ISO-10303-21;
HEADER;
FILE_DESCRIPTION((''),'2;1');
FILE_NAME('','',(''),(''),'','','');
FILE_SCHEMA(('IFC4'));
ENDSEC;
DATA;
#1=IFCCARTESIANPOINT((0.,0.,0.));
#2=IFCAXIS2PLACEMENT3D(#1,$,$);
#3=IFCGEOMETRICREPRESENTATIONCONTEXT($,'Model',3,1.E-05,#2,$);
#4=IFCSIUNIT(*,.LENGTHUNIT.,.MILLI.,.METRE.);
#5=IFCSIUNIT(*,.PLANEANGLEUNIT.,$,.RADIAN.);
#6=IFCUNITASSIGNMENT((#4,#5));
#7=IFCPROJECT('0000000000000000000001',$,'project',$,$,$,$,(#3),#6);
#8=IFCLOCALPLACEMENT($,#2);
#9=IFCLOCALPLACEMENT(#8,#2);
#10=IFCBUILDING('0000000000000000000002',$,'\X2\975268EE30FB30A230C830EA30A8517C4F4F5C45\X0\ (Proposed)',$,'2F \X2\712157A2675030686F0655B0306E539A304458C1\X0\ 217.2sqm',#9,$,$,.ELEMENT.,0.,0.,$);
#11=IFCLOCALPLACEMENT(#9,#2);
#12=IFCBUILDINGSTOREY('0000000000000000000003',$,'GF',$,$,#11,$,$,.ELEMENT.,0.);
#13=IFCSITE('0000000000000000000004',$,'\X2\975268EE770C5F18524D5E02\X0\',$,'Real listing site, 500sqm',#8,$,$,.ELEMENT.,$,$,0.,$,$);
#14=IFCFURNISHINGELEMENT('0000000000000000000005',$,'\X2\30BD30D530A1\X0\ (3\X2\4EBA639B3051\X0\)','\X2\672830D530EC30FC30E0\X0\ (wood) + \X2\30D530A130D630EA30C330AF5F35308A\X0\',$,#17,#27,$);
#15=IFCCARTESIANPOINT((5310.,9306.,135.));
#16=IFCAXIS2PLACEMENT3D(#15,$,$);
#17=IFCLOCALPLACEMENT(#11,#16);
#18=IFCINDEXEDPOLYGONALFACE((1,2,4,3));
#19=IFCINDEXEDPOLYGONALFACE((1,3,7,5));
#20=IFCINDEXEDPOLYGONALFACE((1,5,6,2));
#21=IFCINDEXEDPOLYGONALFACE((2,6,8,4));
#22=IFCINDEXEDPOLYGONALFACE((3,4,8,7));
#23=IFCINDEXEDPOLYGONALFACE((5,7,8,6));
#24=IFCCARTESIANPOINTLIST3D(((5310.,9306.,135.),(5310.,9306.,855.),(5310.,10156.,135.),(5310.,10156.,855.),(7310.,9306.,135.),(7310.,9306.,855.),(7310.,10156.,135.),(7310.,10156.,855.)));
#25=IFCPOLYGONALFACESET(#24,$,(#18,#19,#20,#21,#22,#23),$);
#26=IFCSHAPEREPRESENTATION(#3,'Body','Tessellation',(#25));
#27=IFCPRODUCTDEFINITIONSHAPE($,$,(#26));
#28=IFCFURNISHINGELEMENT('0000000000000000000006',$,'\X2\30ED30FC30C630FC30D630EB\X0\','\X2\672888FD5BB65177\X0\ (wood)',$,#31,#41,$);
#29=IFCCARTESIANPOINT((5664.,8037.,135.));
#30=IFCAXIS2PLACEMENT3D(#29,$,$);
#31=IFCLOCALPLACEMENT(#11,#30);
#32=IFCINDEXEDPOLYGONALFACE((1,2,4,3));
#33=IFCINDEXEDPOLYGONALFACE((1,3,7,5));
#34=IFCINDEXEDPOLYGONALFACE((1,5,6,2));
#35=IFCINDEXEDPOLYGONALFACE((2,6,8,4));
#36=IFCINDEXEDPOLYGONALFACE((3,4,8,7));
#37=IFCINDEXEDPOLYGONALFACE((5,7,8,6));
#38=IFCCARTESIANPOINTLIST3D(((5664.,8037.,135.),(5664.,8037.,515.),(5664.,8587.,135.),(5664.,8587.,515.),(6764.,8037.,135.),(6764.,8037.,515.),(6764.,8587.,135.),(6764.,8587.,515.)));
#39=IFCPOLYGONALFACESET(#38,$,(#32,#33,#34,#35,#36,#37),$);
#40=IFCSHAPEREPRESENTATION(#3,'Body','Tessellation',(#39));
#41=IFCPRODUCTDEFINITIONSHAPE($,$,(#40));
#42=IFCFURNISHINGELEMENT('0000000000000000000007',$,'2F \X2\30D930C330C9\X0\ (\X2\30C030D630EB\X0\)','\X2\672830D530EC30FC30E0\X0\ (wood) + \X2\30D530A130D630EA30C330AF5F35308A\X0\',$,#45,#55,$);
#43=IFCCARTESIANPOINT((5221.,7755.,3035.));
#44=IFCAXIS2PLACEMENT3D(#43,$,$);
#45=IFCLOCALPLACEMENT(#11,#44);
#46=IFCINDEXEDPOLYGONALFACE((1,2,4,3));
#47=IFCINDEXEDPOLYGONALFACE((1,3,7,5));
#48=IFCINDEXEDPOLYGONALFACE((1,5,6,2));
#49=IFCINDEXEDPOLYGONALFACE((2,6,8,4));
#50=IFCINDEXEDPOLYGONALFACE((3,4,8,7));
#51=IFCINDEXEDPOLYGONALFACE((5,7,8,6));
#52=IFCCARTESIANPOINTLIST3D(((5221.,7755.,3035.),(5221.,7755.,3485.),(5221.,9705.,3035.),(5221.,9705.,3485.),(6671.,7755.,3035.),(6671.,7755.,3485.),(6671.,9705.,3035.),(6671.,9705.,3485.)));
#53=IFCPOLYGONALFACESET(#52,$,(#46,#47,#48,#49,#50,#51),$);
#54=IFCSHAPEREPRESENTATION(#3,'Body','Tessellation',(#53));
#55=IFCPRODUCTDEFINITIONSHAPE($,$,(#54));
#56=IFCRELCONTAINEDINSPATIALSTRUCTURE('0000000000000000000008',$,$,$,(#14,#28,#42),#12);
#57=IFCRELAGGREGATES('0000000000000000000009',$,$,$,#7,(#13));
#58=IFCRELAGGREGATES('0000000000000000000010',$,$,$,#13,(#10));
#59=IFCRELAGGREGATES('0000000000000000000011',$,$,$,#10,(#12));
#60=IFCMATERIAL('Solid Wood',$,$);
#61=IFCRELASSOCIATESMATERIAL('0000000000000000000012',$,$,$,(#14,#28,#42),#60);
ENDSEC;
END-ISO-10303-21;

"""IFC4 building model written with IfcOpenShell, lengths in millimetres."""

from ifc_helpers import new_model, si_unit, frame, frame_2d, origin, place, context, project, spatial, rectangle, extrude, material, element, save


model = new_model("IFC4")

# Units and contexts
model_context = context("Model", 3, precision=1e-05, world=origin())
ifc_project = project(units=[si_unit("LENGTHUNIT", "METRE", prefix="MILLI"), si_unit("PLANEANGLEUNIT", "RADIAN")], contexts=[model_context])

# Site, building, storey
site_placement = place(None, origin())
site = spatial("IfcSite", under=ifc_project, at=site_placement, Name="青森県弘前市", ObjectType="Real listing site, 500sqm", CompositionType="ELEMENT", RefElevation=0.0)
building_placement = place(site_placement, origin())
building = spatial("IfcBuilding", under=site, at=building_placement, Name="青森・アトリエ兼住居 (Proposed)", ObjectType="2F 無垢材と漆喰の厚い壁 217.2sqm", CompositionType="ELEMENT", ElevationOfRefHeight=0.0, ElevationOfTerrain=0.0)
storey_placement = place(building_placement, origin())
storey = spatial("IfcBuildingStorey", under=building, at=storey_placement, Name="GF", CompositionType="ELEMENT", Elevation=0.0)

# Shared definitions
ifc_material_1 = material(Name="Solid Wood")

# Furnishing elements
furnishing_1_placement = place(storey_placement, frame((5310.0, 9306.0, 135.0)))
element("IfcFurnishingElement", 1, at=furnishing_1_placement, inside=storey, material=ifc_material_1, Name="ソファ (3人掛け)", Description="木フレーム (wood) + ファブリック張り", context=model_context, shape_type="SweptSolid", body=[
    extrude(rectangle(XDim=2000.0, YDim=850.0, at=frame_2d((1000.0, 425.0))), frame((5310.0, 9306.0, 135.0)), (0.0, 0.0, 1.0), 720.0),
])
furnishing_2_placement = place(storey_placement, frame((5664.0, 8037.0, 135.0)))
element("IfcFurnishingElement", 2, at=furnishing_2_placement, inside=storey, material=ifc_material_1, Name="ローテーブル", Description="木製家具 (wood)", context=model_context, shape_type="SweptSolid", body=[
    extrude(rectangle(XDim=1100.0, YDim=550.0, at=frame_2d((550.0, 275.0))), frame((5664.0, 8037.0, 135.0)), (0.0, 0.0, 1.0), 380.0),
])
furnishing_3_placement = place(storey_placement, frame((5221.0, 7755.0, 3035.0)))
element("IfcFurnishingElement", 3, at=furnishing_3_placement, inside=storey, material=ifc_material_1, Name="2F ベッド (ダブル)", Description="木フレーム (wood) + ファブリック張り", context=model_context, shape_type="SweptSolid", body=[
    extrude(rectangle(XDim=1450.0, YDim=1950.0, at=frame_2d((725.0, 975.0))), frame((5221.0, 7755.0, 3035.0)), (0.0, 0.0, 1.0), 450.0),
])

save(model, "model.ifc")
